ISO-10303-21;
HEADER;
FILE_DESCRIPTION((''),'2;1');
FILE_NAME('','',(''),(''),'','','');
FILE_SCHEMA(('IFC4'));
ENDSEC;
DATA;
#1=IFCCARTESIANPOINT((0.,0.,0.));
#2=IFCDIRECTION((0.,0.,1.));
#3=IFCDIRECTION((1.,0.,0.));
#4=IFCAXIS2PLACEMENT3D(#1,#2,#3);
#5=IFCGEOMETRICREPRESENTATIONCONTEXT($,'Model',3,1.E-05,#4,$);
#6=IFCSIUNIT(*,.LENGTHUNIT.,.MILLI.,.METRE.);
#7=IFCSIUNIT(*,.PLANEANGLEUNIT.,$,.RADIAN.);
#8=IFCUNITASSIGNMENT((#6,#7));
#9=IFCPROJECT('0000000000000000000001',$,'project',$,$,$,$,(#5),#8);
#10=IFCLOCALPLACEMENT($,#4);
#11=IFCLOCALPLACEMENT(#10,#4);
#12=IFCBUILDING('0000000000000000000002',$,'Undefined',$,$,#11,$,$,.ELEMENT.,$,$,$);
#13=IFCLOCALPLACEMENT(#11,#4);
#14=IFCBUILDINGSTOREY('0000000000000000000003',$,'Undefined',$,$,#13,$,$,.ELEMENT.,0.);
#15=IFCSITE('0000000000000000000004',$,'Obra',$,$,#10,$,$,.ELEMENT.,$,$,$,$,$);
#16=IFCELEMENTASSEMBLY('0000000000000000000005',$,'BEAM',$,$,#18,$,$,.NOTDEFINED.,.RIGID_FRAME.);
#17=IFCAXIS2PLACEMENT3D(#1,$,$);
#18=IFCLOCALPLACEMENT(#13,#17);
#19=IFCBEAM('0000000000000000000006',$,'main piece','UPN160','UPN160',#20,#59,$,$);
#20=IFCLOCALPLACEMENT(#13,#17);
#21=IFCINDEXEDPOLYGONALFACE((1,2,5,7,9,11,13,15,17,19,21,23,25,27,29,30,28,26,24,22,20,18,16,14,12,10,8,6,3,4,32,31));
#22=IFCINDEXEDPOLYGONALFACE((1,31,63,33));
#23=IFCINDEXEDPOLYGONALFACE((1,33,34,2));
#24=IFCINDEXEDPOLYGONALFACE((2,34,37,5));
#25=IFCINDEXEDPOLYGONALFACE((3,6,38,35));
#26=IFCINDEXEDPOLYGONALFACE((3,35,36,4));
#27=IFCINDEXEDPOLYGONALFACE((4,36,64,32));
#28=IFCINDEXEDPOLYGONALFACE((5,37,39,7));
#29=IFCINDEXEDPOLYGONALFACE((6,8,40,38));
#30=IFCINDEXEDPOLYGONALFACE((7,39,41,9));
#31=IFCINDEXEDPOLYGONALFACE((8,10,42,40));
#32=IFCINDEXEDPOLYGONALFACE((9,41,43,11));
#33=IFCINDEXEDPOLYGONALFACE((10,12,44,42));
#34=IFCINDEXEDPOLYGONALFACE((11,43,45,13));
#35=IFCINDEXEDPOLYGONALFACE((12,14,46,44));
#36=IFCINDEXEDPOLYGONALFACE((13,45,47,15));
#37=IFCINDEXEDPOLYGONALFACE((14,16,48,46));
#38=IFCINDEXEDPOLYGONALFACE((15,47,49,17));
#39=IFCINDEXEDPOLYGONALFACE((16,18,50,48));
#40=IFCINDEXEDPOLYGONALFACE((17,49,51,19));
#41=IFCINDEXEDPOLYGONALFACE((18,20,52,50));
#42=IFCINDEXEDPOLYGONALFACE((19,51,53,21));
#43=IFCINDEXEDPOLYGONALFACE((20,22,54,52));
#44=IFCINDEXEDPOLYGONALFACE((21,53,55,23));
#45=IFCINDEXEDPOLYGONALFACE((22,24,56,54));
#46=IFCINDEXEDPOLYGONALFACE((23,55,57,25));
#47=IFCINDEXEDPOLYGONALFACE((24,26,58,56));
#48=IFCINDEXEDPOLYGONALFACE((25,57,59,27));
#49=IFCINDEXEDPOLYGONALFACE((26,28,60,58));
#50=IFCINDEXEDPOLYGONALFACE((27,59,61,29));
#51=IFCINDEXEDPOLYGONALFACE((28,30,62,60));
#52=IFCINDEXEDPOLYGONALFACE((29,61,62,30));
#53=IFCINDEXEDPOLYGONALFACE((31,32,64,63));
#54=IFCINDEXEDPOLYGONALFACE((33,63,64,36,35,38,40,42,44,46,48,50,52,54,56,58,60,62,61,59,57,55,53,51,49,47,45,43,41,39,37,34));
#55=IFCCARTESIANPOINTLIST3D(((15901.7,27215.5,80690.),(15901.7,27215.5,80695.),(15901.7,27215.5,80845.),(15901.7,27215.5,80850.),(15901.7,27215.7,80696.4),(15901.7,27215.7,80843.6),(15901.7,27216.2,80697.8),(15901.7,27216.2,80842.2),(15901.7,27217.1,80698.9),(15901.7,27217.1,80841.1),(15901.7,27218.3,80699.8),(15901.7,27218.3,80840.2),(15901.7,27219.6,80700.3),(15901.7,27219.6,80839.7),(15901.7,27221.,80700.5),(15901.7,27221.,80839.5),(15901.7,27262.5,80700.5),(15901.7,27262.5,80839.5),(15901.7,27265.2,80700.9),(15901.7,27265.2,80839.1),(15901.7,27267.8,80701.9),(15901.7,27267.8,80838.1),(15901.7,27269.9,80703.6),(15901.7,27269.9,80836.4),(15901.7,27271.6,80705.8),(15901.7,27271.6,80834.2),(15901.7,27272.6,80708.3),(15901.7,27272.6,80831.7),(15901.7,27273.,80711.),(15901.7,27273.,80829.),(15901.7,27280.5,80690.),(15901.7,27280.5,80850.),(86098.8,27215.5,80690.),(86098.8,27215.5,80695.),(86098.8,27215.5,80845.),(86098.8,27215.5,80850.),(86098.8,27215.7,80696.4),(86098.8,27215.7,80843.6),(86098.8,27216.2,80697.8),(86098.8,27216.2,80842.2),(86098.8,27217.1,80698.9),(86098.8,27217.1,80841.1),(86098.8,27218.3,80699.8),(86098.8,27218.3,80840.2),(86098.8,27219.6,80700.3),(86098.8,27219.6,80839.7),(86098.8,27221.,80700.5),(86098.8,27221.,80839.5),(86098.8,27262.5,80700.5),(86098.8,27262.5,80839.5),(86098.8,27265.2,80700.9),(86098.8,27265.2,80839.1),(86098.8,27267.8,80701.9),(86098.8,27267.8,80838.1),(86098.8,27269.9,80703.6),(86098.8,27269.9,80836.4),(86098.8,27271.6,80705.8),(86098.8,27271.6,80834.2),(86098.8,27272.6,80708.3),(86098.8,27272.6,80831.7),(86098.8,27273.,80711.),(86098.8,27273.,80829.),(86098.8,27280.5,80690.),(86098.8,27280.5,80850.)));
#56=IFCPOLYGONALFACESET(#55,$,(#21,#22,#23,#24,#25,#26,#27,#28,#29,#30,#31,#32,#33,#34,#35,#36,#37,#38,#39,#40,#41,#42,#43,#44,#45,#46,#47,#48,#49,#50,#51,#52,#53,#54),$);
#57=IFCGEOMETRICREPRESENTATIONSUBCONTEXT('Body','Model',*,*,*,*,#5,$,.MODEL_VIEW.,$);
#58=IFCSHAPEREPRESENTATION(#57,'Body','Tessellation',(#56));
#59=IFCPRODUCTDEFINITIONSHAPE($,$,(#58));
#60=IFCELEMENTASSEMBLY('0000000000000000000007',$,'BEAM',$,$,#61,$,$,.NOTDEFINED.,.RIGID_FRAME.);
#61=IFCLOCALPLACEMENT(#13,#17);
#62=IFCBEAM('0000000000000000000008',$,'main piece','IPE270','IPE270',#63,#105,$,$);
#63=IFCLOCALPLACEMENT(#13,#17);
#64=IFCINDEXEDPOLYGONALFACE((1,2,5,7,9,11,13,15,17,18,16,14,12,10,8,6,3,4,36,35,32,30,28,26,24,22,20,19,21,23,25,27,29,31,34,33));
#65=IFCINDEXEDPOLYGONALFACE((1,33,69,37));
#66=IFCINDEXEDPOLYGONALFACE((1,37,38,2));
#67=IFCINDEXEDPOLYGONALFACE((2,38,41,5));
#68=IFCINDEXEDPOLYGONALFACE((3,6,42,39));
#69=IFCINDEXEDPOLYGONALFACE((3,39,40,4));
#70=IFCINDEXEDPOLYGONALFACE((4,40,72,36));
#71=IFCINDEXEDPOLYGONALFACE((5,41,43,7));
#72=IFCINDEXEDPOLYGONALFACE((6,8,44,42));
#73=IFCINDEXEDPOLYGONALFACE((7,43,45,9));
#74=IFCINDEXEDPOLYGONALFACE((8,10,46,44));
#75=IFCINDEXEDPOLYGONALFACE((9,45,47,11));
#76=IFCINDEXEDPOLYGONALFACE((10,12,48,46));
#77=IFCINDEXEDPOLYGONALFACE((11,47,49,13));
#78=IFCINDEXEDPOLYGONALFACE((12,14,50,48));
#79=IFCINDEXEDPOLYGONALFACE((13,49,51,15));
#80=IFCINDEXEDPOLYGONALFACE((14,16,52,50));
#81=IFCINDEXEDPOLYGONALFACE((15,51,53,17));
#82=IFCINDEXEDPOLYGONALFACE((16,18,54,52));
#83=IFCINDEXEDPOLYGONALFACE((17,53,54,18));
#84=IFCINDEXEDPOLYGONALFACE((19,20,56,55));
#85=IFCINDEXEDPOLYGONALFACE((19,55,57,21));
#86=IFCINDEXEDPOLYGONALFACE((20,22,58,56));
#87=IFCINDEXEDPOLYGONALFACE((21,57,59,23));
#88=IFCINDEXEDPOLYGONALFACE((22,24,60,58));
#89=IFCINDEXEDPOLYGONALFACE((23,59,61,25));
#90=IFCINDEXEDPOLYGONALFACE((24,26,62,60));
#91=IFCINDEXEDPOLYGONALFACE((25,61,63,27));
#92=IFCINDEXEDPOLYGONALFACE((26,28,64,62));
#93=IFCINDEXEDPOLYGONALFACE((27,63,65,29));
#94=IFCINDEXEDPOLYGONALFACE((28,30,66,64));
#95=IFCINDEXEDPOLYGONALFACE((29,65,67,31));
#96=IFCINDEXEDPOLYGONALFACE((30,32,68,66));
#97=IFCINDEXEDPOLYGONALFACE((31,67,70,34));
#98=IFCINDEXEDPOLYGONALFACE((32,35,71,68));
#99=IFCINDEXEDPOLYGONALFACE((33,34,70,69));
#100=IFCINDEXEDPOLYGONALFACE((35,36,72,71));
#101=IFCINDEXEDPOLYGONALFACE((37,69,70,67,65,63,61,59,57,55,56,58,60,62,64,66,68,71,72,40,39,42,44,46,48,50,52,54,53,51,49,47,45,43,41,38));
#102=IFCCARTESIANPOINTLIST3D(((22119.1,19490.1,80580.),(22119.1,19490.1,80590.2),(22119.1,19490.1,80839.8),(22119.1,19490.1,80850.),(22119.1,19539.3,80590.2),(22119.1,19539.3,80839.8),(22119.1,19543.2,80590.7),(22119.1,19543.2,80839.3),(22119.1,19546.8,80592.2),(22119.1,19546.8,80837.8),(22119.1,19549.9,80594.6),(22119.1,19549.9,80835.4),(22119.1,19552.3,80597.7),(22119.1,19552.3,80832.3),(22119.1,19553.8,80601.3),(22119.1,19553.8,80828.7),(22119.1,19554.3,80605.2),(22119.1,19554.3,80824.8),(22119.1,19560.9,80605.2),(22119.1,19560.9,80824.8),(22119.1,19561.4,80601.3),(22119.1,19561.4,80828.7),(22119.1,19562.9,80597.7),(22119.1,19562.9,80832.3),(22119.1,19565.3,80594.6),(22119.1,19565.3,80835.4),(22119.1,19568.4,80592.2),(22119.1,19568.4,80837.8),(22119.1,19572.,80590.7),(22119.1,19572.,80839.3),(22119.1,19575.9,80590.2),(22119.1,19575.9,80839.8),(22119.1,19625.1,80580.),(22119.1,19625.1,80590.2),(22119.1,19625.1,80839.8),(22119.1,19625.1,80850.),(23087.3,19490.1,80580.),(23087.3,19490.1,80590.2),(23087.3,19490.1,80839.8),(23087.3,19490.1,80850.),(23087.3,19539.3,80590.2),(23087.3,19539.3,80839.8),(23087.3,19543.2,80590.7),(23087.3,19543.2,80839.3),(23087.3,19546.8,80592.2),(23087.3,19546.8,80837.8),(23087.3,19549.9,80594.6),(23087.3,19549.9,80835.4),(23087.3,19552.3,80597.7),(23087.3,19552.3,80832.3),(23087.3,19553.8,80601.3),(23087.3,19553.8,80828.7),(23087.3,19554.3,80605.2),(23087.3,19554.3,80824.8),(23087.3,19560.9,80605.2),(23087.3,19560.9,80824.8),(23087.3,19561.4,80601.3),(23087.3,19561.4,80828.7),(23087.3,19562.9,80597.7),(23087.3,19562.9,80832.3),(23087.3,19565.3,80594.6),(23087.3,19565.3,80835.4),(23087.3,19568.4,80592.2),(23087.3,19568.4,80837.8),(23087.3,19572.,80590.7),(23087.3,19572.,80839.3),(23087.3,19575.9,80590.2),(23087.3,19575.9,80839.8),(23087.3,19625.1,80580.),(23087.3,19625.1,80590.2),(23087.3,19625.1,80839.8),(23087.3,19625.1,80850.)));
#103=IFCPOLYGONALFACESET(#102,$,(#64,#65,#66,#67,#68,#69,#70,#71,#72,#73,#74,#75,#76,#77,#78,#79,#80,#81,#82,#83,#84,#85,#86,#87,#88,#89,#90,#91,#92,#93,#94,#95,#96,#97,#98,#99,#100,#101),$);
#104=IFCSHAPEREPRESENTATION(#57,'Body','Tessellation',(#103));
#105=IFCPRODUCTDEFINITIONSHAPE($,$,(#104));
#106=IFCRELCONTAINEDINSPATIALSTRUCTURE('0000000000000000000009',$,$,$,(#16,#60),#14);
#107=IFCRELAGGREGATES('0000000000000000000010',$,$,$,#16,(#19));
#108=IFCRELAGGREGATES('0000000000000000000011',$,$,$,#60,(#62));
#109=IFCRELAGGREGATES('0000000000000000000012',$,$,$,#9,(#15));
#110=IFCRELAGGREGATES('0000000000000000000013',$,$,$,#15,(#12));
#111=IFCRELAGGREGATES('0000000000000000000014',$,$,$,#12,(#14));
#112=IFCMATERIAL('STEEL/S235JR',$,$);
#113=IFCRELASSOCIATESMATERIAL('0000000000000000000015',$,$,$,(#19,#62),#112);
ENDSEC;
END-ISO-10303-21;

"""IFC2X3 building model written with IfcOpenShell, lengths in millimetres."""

from ifc_helpers import new_model, si_unit, frame, origin_with_axes, origin_2d_with_axis, place, context, subcontext, project, spatial, i_section, u_section, extrude, material, element, aggregate, save


model = new_model("IFC2X3")

# Units and contexts
model_context = context("Model", 3, precision=1e-05, world=origin_with_axes())
body_context = subcontext(model_context, "Body", "Model", "MODEL_VIEW")
ifc_project = project(units=[si_unit("LENGTHUNIT", "METRE", prefix="MILLI"), si_unit("PLANEANGLEUNIT", "RADIAN")], contexts=[model_context])

# Site, building, storey
site_placement = place(None, origin_with_axes())
site = spatial("IfcSite", under=ifc_project, at=site_placement, Name="Obra", CompositionType="ELEMENT")
building_placement = place(site_placement, origin_with_axes())
building = spatial("IfcBuilding", under=site, at=building_placement, Name="Undefined", CompositionType="ELEMENT")
storey_placement = place(building_placement, origin_with_axes())
storey = spatial("IfcBuildingStorey", under=building, at=storey_placement, Name="Undefined", CompositionType="ELEMENT", Elevation=0.0)

# Element assemblies, beams
ifc_material = material(Name="STEEL/S235JR")
assembly_1_placement = place(storey_placement, origin_with_axes())
assembly_1 = element("IfcElementAssembly", 1, at=assembly_1_placement, inside=storey, Name="BEAM", AssemblyPlace="NOTDEFINED", PredefinedType="RIGID_FRAME")
beam_1_placement = place(assembly_1_placement, frame((15901.7, 27248.0, 80770.0), z_axis=(0.0, 0.0, 1.0), x_axis=(1.0, 0.0, 0.0)))
beam_1 = element("IfcBeam", 2, at=beam_1_placement, material=ifc_material, Name="main piece", Description="UPN160", ObjectType="UPN160", context=body_context, shape_type="SweptSolid", body=[
    extrude(u_section(Depth=160.0, FlangeWidth=65.0, WebThickness=7.5, FlangeThickness=10.5, FilletRadius=10.5, EdgeRadius=5.5, at=origin_2d_with_axis()), frame((70197.1, 0.0, 0.0), z_axis=(-1.0, 0.0, 0.0), x_axis=(0.0, -1.0, 0.0)), (0.0, 0.0, 1.0), 70197.1),
])
aggregate(assembly_1, [beam_1])
assembly_2_placement = place(storey_placement, origin_with_axes())
assembly_2 = element("IfcElementAssembly", 3, at=assembly_2_placement, inside=storey, Name="BEAM", AssemblyPlace="NOTDEFINED", PredefinedType="RIGID_FRAME")
beam_2_placement = place(assembly_2_placement, frame((22119.1, 19557.6, 80715.0), z_axis=(0.0, 0.0, 1.0), x_axis=(1.0, 0.0, 0.0)))
beam_2 = element("IfcBeam", 4, at=beam_2_placement, material=ifc_material, Name="main piece", Description="IPE270", ObjectType="IPE270", context=body_context, shape_type="SweptSolid", body=[
    extrude(i_section(OverallWidth=135.0, OverallDepth=270.0, WebThickness=6.6, FlangeThickness=10.2, FilletRadius=15.0, at=origin_2d_with_axis()), frame((968.2, 0.0, 0.0), z_axis=(-1.0, 0.0, 0.0), x_axis=(0.0, -1.0, 0.0)), (0.0, 0.0, 1.0), 968.2),
])
aggregate(assembly_2, [beam_2])

save(model, "model.ifc")
